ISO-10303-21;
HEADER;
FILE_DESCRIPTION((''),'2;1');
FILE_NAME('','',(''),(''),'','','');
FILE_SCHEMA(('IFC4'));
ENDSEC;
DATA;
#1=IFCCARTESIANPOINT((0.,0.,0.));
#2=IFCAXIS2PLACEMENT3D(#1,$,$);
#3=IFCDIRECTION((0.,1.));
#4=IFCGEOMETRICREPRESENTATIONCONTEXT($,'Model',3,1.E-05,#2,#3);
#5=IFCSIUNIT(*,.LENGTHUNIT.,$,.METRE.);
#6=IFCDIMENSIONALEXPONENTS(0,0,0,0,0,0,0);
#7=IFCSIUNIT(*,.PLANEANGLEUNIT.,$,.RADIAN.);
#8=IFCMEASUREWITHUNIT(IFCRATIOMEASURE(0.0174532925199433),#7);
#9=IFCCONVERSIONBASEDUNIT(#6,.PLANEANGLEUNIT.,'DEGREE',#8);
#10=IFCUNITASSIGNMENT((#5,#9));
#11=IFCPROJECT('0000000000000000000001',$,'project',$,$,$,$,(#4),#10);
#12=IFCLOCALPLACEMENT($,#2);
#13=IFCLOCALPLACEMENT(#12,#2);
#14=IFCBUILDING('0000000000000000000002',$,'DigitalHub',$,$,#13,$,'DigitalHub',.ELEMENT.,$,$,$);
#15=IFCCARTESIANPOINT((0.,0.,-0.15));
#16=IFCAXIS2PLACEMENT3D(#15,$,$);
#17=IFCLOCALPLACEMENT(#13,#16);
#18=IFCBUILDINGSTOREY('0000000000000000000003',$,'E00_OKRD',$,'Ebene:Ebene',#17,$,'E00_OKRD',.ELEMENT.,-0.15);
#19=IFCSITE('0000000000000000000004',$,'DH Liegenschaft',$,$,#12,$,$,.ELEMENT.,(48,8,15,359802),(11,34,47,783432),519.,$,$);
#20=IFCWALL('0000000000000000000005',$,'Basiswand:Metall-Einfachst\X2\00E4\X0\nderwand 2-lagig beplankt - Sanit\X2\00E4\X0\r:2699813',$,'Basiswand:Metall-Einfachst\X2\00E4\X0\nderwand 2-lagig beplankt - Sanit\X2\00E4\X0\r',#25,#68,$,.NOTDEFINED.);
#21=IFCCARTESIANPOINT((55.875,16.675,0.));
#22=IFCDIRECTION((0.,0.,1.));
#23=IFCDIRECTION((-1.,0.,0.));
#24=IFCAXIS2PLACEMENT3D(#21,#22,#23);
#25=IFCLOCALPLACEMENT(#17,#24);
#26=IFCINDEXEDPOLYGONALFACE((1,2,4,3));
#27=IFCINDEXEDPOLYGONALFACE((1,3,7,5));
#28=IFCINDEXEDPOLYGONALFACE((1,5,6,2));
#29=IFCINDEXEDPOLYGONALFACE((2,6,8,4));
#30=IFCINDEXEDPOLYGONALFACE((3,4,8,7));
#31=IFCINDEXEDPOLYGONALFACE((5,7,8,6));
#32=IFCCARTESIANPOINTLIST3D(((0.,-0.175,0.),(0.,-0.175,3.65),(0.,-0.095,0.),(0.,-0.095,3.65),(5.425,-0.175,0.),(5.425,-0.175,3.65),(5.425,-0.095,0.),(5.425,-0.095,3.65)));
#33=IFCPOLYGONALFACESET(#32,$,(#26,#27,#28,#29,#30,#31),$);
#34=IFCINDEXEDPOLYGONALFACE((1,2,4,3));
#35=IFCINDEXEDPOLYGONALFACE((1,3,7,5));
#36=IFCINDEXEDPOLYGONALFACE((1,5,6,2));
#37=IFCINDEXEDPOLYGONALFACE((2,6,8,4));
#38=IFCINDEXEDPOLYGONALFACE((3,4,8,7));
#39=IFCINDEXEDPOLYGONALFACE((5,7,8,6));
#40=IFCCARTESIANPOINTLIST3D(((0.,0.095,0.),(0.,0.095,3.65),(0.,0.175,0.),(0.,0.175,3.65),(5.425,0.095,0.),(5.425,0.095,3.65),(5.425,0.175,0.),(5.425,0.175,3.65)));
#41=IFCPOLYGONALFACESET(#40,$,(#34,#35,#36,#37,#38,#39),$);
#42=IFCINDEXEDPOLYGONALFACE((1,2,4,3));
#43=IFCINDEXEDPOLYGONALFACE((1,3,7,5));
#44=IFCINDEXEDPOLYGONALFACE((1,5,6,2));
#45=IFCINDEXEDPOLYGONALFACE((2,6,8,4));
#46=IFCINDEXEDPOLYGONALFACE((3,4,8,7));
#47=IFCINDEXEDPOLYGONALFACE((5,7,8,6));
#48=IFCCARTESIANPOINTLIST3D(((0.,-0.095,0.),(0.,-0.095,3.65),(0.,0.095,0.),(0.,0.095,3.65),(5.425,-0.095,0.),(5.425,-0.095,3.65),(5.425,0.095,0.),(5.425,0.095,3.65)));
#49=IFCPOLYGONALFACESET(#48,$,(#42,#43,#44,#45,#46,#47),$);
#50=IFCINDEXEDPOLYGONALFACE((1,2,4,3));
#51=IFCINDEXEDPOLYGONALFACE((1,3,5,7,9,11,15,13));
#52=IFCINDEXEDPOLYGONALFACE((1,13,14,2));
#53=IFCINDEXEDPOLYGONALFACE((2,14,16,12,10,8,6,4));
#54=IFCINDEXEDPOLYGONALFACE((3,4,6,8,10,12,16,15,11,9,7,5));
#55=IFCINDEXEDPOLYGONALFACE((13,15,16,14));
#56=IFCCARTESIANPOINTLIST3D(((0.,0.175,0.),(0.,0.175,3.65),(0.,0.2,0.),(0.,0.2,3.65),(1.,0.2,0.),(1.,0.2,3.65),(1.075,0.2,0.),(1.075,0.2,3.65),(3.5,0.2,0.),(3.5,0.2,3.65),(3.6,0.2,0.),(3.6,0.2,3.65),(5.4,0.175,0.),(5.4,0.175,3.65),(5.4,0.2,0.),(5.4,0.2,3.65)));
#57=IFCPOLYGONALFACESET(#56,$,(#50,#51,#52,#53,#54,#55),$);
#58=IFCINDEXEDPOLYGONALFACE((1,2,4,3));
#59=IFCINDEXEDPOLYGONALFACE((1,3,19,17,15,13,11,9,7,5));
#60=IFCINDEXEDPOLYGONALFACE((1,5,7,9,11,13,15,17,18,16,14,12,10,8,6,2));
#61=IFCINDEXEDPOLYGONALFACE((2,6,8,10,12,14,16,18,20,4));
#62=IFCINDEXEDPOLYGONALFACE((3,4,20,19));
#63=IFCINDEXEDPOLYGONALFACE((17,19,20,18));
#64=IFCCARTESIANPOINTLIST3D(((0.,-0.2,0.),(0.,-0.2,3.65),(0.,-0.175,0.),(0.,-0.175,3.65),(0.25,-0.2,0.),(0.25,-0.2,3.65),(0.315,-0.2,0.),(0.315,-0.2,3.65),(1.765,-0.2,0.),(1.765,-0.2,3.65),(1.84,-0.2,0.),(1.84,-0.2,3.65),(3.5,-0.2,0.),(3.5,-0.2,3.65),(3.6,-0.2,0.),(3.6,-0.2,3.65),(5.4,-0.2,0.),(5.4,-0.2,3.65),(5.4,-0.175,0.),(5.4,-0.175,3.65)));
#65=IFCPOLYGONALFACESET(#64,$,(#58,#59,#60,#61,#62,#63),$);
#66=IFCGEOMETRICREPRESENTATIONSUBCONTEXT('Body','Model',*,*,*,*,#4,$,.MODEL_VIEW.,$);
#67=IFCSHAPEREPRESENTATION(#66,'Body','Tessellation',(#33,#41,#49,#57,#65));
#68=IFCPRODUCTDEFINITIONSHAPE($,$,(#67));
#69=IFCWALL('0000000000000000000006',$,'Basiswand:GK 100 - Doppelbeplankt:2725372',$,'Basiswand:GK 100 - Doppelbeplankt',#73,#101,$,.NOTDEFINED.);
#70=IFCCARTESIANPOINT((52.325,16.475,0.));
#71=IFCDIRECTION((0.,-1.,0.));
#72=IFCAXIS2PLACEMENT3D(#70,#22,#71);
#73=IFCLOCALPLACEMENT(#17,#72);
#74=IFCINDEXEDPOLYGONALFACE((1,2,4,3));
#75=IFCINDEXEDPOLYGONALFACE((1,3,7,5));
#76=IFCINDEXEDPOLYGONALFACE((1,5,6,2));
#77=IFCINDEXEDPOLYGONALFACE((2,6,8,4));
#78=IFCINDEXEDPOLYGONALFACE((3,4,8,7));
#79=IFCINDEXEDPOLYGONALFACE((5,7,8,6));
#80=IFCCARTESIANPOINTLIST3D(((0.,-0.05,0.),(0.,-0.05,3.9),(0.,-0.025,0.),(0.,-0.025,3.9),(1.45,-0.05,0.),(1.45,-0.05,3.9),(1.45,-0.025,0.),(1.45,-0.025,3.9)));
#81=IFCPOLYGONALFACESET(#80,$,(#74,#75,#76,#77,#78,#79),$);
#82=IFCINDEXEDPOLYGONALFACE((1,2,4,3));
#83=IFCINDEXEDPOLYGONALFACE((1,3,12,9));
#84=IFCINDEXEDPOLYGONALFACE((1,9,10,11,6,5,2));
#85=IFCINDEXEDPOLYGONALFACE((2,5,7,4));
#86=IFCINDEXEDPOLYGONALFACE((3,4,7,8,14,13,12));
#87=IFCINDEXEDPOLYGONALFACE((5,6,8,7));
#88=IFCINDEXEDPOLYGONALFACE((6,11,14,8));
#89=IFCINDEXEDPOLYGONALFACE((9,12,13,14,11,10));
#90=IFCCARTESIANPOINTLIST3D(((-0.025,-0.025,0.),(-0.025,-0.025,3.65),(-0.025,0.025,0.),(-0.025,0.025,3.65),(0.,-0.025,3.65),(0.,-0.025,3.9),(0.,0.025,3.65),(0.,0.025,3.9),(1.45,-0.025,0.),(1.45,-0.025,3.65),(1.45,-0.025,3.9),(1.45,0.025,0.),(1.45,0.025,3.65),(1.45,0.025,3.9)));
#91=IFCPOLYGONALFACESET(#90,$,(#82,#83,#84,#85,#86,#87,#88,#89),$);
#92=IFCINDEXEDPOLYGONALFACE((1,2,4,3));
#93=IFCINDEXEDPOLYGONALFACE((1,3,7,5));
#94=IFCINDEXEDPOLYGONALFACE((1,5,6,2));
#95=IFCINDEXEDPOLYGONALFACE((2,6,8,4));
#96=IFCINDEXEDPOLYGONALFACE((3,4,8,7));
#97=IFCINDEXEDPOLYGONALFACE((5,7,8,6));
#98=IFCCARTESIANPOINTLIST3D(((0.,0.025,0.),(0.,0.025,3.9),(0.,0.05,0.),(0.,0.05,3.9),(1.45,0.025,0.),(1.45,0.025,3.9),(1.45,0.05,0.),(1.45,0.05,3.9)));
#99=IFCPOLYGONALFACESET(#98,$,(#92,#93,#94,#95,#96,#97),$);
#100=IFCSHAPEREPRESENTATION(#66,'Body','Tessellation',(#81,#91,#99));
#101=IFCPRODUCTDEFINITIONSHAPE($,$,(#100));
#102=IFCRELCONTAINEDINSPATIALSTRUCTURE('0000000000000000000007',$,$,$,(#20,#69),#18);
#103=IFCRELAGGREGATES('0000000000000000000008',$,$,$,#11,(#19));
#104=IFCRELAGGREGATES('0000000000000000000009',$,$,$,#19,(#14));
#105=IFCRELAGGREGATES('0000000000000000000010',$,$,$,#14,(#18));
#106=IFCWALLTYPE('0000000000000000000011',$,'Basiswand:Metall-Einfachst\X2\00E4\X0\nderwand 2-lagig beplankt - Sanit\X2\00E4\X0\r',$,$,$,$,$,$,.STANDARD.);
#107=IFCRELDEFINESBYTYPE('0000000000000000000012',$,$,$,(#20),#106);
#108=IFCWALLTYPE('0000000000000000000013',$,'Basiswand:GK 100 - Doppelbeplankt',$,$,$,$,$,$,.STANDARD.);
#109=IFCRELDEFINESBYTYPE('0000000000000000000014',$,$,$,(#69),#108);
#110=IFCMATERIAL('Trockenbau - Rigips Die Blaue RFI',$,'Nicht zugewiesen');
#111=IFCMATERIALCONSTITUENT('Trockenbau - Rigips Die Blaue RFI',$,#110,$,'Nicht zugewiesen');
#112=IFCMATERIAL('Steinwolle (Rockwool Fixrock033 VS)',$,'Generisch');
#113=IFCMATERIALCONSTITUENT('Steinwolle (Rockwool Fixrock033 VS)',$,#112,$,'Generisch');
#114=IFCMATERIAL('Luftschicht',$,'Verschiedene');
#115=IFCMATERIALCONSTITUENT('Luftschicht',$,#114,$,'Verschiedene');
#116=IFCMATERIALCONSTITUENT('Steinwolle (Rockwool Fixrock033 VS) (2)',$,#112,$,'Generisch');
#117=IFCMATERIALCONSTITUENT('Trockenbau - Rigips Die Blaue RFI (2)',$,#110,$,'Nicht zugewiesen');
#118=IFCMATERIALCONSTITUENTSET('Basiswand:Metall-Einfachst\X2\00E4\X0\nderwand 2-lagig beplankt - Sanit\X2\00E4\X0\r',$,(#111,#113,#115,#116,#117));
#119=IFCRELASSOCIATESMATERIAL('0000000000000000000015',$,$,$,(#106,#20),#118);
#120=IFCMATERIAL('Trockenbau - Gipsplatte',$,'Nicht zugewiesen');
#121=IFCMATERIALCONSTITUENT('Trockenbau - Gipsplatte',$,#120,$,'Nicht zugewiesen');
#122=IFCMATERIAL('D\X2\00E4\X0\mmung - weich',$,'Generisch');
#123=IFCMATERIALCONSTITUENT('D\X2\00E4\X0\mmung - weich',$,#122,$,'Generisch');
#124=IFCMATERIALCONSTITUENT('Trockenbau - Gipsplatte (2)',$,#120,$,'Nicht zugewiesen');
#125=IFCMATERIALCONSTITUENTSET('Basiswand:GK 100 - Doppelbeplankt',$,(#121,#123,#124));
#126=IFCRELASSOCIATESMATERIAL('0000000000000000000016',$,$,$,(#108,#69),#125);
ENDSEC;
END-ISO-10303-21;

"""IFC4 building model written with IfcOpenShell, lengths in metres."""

from ifc_helpers import new_model, entity, si_unit, converted_unit, direction, frame, origin, place, context, subcontext, project, spatial, indexed_curve, outline, extrude, material, constituent, constituent_set, type_object, element, save


model = new_model("IFC4")

# Units and contexts
model_context = context("Model", 3, precision=1e-05, world=origin(), true_north=direction((0.0, 1.0)))
body_context = subcontext(model_context, "Body", "Model", "MODEL_VIEW")
ifc_project = project(units=[si_unit("LENGTHUNIT", "METRE"), converted_unit("PLANEANGLEUNIT", "DEGREE", entity("IfcRatioMeasure", 0.0174532925199433), si_unit("PLANEANGLEUNIT", "RADIAN"), dimensions=[0, 0, 0, 0, 0, 0, 0])], contexts=[model_context])

# Site, building, storey
site_placement = place(None, frame((0.0, 0.0, 0.0)))
site = spatial("IfcSite", under=ifc_project, at=site_placement, Name="DH Liegenschaft", CompositionType="ELEMENT", RefLatitude=(48, 8, 15, 359802), RefLongitude=(11, 34, 47, 783432), RefElevation=519.0)
building_placement = place(site_placement, origin())
building = spatial("IfcBuilding", under=site, at=building_placement, Name="DigitalHub", LongName="DigitalHub", CompositionType="ELEMENT")
storey_placement = place(building_placement, frame((0.0, 0.0, -0.15)))
storey = spatial("IfcBuildingStorey", under=building, at=storey_placement, Name="E00_OKRD", ObjectType="Ebene:Ebene", LongName="E00_OKRD", CompositionType="ELEMENT", Elevation=-0.15)

# Shared definitions
ifc_material_1 = material(Name="Trockenbau - Rigips Die Blaue RFI", Category="Nicht zugewiesen")

# Walls
ifc_constituent_1 = constituent(ifc_material_1, Name="Trockenbau - Rigips Die Blaue RFI", Category="Nicht zugewiesen")
ifc_material_2 = material(Name="Steinwolle (Rockwool Fixrock033 VS)", Category="Generisch")
ifc_constituent_2 = constituent(ifc_material_2, Name="Steinwolle (Rockwool Fixrock033 VS)", Category="Generisch")
ifc_material_3 = material(Name="Luftschicht", Category="Verschiedene")
ifc_constituent_3 = constituent(ifc_material_3, Name="Luftschicht", Category="Verschiedene")
ifc_constituent_4 = constituent(ifc_material_2, Name="Steinwolle (Rockwool Fixrock033 VS) (2)", Category="Generisch")
ifc_constituent_5 = constituent(ifc_material_1, Name="Trockenbau - Rigips Die Blaue RFI (2)", Category="Nicht zugewiesen")
ifc_constituent_set_1 = constituent_set(constituents=[ifc_constituent_1, ifc_constituent_2, ifc_constituent_3, ifc_constituent_4, ifc_constituent_5], Name="Basiswand:Metall-Einfachständerwand 2-lagig beplankt - Sanitär")
wall_type_1 = type_object("IfcWallType", Name="Basiswand:Metall-Einfachständerwand 2-lagig beplankt - Sanitär", PredefinedType="STANDARD", material=ifc_constituent_set_1)
wall_1_placement = place(storey_placement, frame((55.875, 16.675, 0.0), z_axis=(0.0, 0.0, 1.0), x_axis=(-1.0, 0.0, 0.0)))
element("IfcWall", 1, at=wall_1_placement, inside=storey, type_object=wall_type_1, material=ifc_constituent_set_1, Name="Basiswand:Metall-Einfachständerwand 2-lagig beplankt - Sanitär:2699813", ObjectType="Basiswand:Metall-Einfachständerwand 2-lagig beplankt - Sanitär", PredefinedType="NOTDEFINED", context=body_context, shape_type="SweptSolid", body=[
    extrude(outline(indexed_curve([(-2.7125, -0.04), (2.7125, -0.04), (2.7125, 0.04), (-2.7125, 0.04), (-2.7125, -0.04)], self_intersect=False)), frame((2.7125, -0.135, 0.0)), (0.0, 0.0, 1.0), 3.65),
    extrude(outline(indexed_curve([(-2.7125, -0.04), (2.7125, -0.04), (2.7125, 0.04), (-2.7125, 0.04), (-2.7125, -0.04)], self_intersect=False)), frame((2.7125, 0.135, 0.0)), (0.0, 0.0, 1.0), 3.65),
    extrude(outline(indexed_curve([(-2.7125, -0.095), (2.7125, -0.095), (2.7125, 0.095), (-2.7125, 0.095), (-2.7125, -0.095)], self_intersect=False)), frame((2.7125, 0.0, 0.0)), (0.0, 0.0, 1.0), 3.65),
    extrude(outline(indexed_curve([(-1.1031, -0.0062), (-1.0031, -0.0062), (1.4219, -0.0063), (1.4969, -0.0063), (2.4969, -0.0063), (2.4969, 0.0187), (-2.9031, 0.0188), (-2.9031, -0.0062), (-1.1031, -0.0062)], self_intersect=False)), frame((2.4969, 0.1938, 0.0), z_axis=(0.0, 0.0, 1.0), x_axis=(-1.0, 0.0, 0.0)), (0.0, 0.0, 1.0), 3.65),
    extrude(outline(indexed_curve([(-1.957, -0.005), (-1.892, -0.005), (-0.442, -0.005), (-0.367, -0.005), (1.293, -0.005), (1.393, -0.005), (3.193, -0.005), (3.193, 0.02), (-2.207, 0.02), (-2.207, -0.005), (-1.957, -0.005)], self_intersect=False)), frame((2.207, -0.195, 0.0)), (0.0, 0.0, 1.0), 3.65),
])
ifc_material_4 = material(Name="Trockenbau - Gipsplatte", Category="Nicht zugewiesen")
ifc_material_5 = material(Name="Dämmung - weich", Category="Generisch")
ifc_constituent_6 = constituent(ifc_material_4, Name="Trockenbau - Gipsplatte", Category="Nicht zugewiesen")
ifc_constituent_7 = constituent(ifc_material_5, Name="Dämmung - weich", Category="Generisch")
ifc_constituent_8 = constituent(ifc_material_4, Name="Trockenbau - Gipsplatte (2)", Category="Nicht zugewiesen")
ifc_constituent_set_2 = constituent_set(constituents=[ifc_constituent_6, ifc_constituent_7, ifc_constituent_8], Name="Basiswand:GK 100 - Doppelbeplankt")
wall_type_2 = type_object("IfcWallType", Name="Basiswand:GK 100 - Doppelbeplankt", PredefinedType="STANDARD", material=ifc_constituent_set_2)
wall_2_placement = place(storey_placement, frame((52.325, 16.475, 0.0), z_axis=(0.0, 0.0, 1.0), x_axis=(0.0, -1.0, 0.0)))
element("IfcWall", 2, at=wall_2_placement, inside=storey, type_object=wall_type_2, material=ifc_constituent_set_2, Name="Basiswand:GK 100 - Doppelbeplankt:2725372", ObjectType="Basiswand:GK 100 - Doppelbeplankt", PredefinedType="NOTDEFINED", context=body_context, shape_type="SweptSolid", body=[
    extrude(outline(indexed_curve([(-0.0125, -0.725), (0.0125, -0.725), (0.0125, 0.725), (-0.0125, 0.725), (-0.0125, -0.725)], self_intersect=False)), frame((0.725, -0.0375, 0.0), z_axis=(0.0, 0.0, 1.0), x_axis=(0.0, 1.0, 0.0)), (0.0, 0.0, 1.0), 3.9),
    extrude(outline(indexed_curve([(-2.6786, -0.6393), (0.9714, -0.6393), (0.9714, -0.6143), (1.2214, -0.6143), (1.2214, 0.8357), (0.9714, 0.8357), (-2.6786, 0.8357), (-2.6786, -0.6393)], self_intersect=False)), frame((0.6143, -0.025, 2.6786), z_axis=(0.0, 1.0, 0.0), x_axis=(0.0, 0.0, 1.0)), (0.0, 0.0, 1.0), 0.05),
    extrude(outline(indexed_curve([(-0.0125, -0.725), (0.0125, -0.725), (0.0125, 0.725), (-0.0125, 0.725), (-0.0125, -0.725)], self_intersect=False)), frame((0.725, 0.0375, 0.0), z_axis=(0.0, 0.0, 1.0), x_axis=(0.0, 1.0, 0.0)), (0.0, 0.0, 1.0), 3.9),
])

save(model, "model.ifc")
